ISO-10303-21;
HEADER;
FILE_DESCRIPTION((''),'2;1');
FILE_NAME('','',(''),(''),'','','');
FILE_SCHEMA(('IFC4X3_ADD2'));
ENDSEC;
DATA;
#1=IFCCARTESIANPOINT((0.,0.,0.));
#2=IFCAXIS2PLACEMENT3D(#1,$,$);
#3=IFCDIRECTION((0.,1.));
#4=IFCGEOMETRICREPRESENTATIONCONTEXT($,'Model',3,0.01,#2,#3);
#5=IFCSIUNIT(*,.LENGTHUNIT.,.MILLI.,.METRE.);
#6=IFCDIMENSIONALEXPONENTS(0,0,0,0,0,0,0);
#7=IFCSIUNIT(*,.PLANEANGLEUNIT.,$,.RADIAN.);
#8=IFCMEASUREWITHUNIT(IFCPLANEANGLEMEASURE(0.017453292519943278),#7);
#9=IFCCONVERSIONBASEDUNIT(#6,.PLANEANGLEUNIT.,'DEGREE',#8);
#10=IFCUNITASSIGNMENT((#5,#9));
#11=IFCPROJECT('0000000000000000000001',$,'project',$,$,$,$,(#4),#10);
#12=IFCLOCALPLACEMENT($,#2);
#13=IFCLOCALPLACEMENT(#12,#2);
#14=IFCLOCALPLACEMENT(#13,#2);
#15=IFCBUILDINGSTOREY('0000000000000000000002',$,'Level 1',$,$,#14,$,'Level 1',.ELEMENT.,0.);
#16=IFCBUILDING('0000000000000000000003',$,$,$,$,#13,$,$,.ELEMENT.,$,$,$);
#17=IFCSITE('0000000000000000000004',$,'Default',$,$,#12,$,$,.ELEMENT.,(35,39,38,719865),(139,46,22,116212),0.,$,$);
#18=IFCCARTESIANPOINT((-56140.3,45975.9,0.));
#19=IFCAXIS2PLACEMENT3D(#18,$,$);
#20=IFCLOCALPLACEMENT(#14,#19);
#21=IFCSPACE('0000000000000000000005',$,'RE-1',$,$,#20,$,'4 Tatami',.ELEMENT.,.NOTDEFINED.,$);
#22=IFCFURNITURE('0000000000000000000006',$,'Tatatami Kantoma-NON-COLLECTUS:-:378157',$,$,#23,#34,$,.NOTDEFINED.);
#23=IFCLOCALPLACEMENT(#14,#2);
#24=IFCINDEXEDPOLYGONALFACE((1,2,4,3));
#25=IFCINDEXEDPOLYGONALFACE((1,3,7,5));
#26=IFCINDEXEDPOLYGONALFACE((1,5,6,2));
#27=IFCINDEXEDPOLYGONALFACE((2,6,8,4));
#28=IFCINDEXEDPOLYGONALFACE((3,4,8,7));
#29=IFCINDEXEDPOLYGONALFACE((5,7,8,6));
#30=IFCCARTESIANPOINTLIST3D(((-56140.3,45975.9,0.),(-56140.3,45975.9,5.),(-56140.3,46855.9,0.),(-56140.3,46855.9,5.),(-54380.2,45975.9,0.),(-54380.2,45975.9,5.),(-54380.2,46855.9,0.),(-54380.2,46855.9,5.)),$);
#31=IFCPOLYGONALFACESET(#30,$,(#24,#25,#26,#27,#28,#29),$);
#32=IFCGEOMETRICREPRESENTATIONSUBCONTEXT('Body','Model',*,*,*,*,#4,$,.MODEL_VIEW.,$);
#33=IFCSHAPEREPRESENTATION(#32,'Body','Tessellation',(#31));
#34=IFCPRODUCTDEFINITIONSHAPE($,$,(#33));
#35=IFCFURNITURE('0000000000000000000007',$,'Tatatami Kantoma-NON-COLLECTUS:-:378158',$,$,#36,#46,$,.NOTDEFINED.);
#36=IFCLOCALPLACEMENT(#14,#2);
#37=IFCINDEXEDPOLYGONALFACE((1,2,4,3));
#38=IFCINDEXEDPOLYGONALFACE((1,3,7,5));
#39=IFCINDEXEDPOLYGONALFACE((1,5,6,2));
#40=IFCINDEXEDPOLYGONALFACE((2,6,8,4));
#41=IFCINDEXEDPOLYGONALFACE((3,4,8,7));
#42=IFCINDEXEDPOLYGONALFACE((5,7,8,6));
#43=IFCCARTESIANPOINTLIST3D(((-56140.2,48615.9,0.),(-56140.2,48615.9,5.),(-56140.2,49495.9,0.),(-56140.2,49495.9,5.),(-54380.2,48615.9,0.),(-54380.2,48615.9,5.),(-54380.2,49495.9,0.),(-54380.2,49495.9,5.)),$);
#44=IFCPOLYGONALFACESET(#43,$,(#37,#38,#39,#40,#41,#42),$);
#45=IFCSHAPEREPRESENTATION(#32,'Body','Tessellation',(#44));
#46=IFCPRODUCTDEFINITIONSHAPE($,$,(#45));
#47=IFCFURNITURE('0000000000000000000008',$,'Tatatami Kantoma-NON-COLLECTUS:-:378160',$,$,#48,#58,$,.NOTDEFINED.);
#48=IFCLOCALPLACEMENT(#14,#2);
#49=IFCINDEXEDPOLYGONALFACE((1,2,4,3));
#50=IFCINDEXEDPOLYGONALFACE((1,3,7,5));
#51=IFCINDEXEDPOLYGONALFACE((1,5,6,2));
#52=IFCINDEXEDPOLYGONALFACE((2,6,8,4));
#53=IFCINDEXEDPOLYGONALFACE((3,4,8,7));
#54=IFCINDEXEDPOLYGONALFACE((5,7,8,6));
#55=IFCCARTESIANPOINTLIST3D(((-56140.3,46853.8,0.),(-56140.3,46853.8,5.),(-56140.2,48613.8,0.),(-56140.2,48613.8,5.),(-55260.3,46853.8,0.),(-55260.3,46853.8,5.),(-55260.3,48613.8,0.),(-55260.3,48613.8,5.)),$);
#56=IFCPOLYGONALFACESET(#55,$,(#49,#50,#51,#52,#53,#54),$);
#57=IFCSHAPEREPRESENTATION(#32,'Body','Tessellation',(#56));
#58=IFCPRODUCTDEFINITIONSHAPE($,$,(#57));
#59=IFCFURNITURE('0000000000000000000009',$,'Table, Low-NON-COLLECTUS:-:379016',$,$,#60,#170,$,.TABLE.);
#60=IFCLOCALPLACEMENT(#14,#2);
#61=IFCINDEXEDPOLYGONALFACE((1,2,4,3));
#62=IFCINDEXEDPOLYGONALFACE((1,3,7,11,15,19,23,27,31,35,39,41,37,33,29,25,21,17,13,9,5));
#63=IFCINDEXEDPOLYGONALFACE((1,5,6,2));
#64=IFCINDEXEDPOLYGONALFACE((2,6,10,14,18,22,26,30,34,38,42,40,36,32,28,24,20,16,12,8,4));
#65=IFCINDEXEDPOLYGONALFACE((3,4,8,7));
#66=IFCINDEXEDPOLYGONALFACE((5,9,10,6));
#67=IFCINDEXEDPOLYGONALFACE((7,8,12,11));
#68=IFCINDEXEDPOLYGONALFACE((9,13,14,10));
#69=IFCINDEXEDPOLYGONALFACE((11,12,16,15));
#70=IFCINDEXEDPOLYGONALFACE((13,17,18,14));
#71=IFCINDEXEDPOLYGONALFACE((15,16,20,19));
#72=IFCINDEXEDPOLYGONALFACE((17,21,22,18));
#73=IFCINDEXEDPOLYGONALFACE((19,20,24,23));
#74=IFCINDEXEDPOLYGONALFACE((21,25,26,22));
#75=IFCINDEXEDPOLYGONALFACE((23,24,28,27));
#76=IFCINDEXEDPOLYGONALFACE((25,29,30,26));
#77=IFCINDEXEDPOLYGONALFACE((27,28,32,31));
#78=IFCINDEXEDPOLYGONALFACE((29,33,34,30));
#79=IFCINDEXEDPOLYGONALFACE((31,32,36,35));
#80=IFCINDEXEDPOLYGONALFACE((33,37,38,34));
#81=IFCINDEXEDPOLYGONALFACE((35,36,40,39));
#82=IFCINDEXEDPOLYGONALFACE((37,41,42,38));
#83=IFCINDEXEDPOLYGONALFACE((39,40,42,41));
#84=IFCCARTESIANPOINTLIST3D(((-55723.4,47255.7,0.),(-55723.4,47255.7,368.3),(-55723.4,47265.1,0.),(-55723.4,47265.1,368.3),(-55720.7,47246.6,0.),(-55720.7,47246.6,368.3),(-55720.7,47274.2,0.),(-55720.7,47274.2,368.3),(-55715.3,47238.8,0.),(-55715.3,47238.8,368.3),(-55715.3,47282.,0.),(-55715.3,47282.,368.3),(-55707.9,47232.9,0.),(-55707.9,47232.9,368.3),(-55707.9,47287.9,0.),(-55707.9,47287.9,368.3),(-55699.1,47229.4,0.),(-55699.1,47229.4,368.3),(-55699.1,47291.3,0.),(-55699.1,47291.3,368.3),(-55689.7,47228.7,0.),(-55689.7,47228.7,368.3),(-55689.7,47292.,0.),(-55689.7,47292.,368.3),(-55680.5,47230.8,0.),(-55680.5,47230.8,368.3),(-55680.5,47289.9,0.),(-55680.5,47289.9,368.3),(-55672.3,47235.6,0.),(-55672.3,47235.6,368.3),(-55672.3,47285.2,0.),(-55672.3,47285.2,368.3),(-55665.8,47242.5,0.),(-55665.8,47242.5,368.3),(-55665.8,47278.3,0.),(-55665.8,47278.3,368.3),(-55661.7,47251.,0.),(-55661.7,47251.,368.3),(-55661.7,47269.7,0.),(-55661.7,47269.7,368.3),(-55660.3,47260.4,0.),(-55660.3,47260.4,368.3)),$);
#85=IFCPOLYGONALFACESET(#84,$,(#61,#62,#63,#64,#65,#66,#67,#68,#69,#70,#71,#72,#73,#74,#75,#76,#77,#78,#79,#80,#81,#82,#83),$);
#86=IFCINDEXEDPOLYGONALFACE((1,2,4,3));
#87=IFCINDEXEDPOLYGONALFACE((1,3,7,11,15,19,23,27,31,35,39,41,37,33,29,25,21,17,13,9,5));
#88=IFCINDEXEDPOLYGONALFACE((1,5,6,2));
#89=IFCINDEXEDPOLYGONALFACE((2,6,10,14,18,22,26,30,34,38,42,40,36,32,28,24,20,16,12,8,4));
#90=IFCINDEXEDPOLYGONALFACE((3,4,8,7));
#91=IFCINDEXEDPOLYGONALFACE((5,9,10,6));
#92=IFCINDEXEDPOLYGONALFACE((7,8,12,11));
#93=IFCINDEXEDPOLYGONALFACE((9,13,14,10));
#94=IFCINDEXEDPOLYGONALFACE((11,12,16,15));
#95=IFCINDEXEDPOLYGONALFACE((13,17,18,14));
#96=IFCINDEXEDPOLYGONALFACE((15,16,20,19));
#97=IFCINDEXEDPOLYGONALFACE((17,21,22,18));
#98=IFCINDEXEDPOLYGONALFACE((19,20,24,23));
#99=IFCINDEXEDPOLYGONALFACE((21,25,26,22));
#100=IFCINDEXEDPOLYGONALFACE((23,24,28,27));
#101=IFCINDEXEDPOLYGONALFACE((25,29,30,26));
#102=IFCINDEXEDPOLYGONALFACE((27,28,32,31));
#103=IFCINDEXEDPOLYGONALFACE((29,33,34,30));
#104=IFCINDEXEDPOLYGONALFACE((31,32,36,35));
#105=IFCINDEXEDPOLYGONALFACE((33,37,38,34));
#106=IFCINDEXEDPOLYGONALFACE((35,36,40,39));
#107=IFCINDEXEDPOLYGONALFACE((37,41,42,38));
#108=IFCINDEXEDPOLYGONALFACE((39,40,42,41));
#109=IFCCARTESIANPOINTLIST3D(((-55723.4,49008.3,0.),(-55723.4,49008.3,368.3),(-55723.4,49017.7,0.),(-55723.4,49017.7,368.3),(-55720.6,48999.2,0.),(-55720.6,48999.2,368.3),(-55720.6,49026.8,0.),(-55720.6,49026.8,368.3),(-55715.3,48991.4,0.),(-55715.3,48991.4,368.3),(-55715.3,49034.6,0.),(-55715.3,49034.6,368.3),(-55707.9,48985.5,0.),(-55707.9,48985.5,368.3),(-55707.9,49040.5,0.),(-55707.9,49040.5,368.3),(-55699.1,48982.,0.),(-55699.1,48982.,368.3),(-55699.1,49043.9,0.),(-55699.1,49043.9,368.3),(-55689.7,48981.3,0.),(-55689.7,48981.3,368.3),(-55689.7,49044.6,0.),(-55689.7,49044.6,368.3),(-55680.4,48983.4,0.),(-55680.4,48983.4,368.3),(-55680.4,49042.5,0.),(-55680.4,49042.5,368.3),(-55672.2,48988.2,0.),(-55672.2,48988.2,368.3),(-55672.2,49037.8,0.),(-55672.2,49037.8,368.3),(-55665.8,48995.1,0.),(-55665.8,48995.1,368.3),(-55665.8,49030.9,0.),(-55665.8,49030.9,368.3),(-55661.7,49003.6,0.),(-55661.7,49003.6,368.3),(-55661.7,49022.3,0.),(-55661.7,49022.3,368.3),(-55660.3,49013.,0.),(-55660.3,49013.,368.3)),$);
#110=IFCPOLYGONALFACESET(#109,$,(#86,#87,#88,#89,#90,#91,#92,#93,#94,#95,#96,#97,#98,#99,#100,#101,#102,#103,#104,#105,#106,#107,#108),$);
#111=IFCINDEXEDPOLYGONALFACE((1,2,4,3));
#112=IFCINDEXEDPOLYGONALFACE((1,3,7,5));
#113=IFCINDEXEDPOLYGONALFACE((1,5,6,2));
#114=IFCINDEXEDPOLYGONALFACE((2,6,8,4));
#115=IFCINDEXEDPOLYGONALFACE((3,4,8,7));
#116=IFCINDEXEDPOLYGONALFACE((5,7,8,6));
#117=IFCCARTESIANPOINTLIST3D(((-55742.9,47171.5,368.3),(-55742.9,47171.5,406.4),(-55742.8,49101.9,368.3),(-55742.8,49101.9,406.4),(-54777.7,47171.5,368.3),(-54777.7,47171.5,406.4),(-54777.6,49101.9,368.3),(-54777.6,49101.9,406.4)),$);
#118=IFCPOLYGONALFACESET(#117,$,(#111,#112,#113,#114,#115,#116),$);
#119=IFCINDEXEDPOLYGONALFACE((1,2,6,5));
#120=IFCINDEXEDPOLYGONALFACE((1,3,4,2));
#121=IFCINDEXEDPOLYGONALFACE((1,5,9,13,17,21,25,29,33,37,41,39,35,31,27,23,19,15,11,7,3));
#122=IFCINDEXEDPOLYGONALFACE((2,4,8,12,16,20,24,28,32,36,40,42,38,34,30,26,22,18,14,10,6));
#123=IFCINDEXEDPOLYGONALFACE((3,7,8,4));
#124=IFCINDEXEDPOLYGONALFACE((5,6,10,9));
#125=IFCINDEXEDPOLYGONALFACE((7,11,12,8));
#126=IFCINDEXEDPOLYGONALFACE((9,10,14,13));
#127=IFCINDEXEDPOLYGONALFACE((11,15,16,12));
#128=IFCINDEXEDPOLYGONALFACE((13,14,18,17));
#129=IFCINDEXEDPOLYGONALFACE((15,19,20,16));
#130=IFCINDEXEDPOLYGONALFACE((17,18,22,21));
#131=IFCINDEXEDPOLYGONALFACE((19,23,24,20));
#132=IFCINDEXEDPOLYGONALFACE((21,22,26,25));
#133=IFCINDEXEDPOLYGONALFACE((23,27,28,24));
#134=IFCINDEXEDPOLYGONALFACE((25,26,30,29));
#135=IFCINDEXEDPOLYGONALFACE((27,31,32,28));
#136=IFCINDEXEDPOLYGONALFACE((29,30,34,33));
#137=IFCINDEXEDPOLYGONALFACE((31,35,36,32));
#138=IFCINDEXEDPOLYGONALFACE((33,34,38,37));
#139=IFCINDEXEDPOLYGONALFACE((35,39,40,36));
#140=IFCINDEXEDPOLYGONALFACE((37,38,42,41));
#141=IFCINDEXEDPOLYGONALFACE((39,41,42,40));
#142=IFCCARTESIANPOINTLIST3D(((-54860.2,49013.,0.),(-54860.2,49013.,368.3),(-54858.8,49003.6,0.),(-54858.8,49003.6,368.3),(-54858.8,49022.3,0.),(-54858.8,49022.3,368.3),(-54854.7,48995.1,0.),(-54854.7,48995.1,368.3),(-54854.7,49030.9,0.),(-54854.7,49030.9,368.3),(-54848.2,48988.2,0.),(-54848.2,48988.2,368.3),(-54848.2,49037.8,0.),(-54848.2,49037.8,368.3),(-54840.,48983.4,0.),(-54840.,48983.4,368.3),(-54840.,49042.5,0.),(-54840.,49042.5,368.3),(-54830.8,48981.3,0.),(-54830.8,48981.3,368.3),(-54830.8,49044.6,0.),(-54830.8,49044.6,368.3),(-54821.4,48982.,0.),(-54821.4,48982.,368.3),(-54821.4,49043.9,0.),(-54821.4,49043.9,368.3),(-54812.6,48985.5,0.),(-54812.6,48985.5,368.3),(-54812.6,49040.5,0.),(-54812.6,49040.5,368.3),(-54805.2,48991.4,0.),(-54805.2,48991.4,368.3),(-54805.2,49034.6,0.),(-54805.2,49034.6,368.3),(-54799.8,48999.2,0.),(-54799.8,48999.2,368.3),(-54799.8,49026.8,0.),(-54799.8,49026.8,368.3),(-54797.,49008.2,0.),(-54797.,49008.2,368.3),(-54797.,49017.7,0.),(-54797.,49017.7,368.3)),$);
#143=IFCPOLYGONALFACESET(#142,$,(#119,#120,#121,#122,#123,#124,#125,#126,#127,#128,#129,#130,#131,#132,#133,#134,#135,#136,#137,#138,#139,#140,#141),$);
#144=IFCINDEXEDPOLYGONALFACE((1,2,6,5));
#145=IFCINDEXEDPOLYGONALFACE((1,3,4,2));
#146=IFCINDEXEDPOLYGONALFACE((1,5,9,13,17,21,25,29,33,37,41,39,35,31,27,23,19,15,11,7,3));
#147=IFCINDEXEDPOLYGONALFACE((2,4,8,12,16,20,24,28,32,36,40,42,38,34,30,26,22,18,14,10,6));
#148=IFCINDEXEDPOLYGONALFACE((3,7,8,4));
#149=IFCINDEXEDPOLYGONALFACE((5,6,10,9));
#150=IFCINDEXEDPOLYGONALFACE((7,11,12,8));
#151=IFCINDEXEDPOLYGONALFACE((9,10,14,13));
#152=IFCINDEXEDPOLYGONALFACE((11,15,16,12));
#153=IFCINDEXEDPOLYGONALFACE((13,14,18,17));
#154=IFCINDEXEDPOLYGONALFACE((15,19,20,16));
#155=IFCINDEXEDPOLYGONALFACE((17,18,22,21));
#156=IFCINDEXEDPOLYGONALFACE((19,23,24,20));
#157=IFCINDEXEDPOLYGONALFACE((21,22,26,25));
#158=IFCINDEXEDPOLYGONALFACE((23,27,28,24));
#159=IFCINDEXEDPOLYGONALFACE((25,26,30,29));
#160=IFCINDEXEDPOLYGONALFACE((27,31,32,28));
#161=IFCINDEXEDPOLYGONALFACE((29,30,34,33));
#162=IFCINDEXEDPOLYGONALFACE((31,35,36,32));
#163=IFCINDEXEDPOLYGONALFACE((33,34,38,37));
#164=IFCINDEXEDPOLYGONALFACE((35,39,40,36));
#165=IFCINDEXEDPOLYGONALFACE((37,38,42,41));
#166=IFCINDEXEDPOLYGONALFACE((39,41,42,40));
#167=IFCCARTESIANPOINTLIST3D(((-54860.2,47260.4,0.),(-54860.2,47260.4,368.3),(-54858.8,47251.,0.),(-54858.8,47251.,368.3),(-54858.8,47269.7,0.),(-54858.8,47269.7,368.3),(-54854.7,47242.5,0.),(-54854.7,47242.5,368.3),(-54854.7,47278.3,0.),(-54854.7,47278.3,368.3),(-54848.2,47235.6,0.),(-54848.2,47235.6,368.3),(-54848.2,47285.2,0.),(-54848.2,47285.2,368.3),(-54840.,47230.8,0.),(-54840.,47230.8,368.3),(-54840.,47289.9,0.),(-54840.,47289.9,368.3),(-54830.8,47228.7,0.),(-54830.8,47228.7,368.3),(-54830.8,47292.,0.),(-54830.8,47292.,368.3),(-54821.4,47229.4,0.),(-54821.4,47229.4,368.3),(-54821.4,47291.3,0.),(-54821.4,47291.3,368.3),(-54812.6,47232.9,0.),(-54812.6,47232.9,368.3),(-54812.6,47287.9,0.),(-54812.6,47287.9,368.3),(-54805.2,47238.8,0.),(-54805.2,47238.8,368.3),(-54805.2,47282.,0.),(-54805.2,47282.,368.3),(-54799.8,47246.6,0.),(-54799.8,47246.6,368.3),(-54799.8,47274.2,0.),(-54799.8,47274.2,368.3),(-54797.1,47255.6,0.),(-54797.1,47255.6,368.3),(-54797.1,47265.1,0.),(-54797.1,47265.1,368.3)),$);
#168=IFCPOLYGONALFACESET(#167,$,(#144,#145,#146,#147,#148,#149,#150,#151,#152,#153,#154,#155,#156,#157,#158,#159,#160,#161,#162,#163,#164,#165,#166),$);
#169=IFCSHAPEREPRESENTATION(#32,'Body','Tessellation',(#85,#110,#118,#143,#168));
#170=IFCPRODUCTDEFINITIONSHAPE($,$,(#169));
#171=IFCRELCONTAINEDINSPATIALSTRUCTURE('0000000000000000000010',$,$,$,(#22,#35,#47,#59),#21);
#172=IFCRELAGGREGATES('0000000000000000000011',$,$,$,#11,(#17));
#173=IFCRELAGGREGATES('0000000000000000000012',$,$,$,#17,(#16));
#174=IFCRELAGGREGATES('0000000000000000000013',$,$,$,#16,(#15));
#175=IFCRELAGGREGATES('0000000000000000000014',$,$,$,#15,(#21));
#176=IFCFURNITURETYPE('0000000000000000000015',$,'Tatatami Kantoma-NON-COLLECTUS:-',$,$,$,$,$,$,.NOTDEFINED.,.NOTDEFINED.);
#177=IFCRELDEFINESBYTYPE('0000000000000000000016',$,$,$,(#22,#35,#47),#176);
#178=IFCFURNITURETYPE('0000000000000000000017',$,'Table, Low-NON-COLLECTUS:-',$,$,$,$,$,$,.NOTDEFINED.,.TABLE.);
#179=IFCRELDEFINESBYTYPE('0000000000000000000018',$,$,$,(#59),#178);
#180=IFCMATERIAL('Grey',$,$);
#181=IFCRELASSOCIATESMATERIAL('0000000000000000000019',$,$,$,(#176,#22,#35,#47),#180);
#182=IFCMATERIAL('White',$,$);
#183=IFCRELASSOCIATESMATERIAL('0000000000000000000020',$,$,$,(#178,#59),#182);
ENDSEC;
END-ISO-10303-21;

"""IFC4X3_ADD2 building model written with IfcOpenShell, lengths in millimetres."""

from ifc_helpers import new_model, entity, si_unit, converted_unit, direction, frame, frame_2d, origin, origin_2d_with_axis, place, context, subcontext, project, spatial, rectangle, circle, extrude, source, transform, mapped, material, type_object, type_shapes, element, save


model = new_model("IFC4X3_ADD2")

# Units and contexts
model_context = context("Model", 3, precision=0.01, world=origin(), true_north=direction((0.0, 1.0)))
body_context = subcontext(model_context, "Body", "Model", "MODEL_VIEW")
ifc_project = project(units=[si_unit("LENGTHUNIT", "METRE", prefix="MILLI"), converted_unit("PLANEANGLEUNIT", "DEGREE", entity("IfcPlaneAngleMeasure", 0.017453292519943278), si_unit("PLANEANGLEUNIT", "RADIAN"), dimensions=[0, 0, 0, 0, 0, 0, 0])], contexts=[model_context])

# Site, building, storey
site_placement = place(None, origin())
site = spatial("IfcSite", under=ifc_project, at=site_placement, Name="Default", CompositionType="ELEMENT", RefLatitude=(35, 39, 38, 719865), RefLongitude=(139, 46, 22, 116212), RefElevation=0.0)
building_placement = place(site_placement, origin())
building = spatial("IfcBuilding", under=site, at=building_placement, CompositionType="ELEMENT")
storey_placement = place(building_placement, origin())
storey = spatial("IfcBuildingStorey", under=building, at=storey_placement, Name="Level 1", LongName="Level 1", CompositionType="ELEMENT", Elevation=0.0)

# Shared definitions
ifc_material_1 = material(Name="White")

# Shared definitions
space_1_placement = place(storey_placement, frame((-56140.3, 45975.9, 0.0)))
space_1 = spatial("IfcSpace", under=storey, at=space_1_placement, Name="RE-1", LongName="4 Tatami", CompositionType="ELEMENT", PredefinedType="NOTDEFINED")

# Furniture
ifc_material_2 = material(Name="Grey")
furniture_type_1 = type_object("IfcFurnitureType", Name="Tatatami Kantoma-NON-COLLECTUS:-", AssemblyPlace="NOTDEFINED", PredefinedType="NOTDEFINED", material=ifc_material_2)
shared_shape_1 = source(origin(), body_context, "Body", "SweptSolid", [
    extrude(rectangle(XDim=1760.0, YDim=880.0, at=origin_2d_with_axis()), frame((880.0, 440.0, 0.0), z_axis=(0.0, 0.0, 1.0), x_axis=(-1.0, 0.0, 0.0)), (0.0, 0.0, 1.0), 5.0),
])
type_shapes(furniture_type_1, [shared_shape_1])
for number, where, name in (
    (1, (0.0, 0.0, 0.0), "Tatatami Kantoma-NON-COLLECTUS:-:378157"),
    (2, (0.0, 2640.0, 0.0), "Tatatami Kantoma-NON-COLLECTUS:-:378158"),
):
    element("IfcFurniture", number, at=place(space_1_placement, frame(where)), inside=space_1, type_object=furniture_type_1, material=ifc_material_2, Name=name, PredefinedType="NOTDEFINED", context=body_context, shape_type="MappedRepresentation", body=[
        mapped(shared_shape_1, transform((0.0, 0.0, 0.0), scale=1.0)),
    ])
for number, where, z_axis, x_axis, name in (
    (3, (0.0, 2637.9, 0.0), (0.0, 0.0, 1.0), (-0.000004, -1.0, 0.0), "Tatatami Kantoma-NON-COLLECTUS:-:378160"),
):
    element("IfcFurniture", number, at=place(space_1_placement, frame(where, z_axis=z_axis, x_axis=x_axis)), inside=space_1, type_object=furniture_type_1, material=ifc_material_2, Name=name, PredefinedType="NOTDEFINED", context=body_context, shape_type="MappedRepresentation", body=[
        mapped(shared_shape_1, transform((0.0, 0.0, 0.0), scale=1.0)),
    ])
furniture_type_2 = type_object("IfcFurnitureType", Name="Table, Low-NON-COLLECTUS:-", AssemblyPlace="NOTDEFINED", PredefinedType="TABLE", material=ifc_material_1)
shared_shape_2 = source(origin(), body_context, "Body", "SweptSolid", [
    extrude(circle(Radius=31.8, at=frame_2d((0.0, 0.0), x_axis=(1.0, 0.0))), frame((876.3, -431.8, 0.0), z_axis=(0.0, 0.0, 1.0), x_axis=(0.0, 1.0, 0.0)), (0.0, 0.0, 1.0), 368.3),
    extrude(circle(Radius=31.8, at=origin_2d_with_axis()), frame((-876.3, -431.8, 0.0), z_axis=(0.0, 0.0, 1.0), x_axis=(0.0, 1.0, 0.0)), (0.0, 0.0, 1.0), 368.3),
    extrude(rectangle(XDim=1930.4, YDim=965.2, at=origin_2d_with_axis()), frame((0.0, 0.0, 368.3), z_axis=(0.0, 0.0, 1.0), x_axis=(-1.0, 0.0, 0.0)), (0.0, 0.0, 1.0), 38.1),
    extrude(circle(Radius=31.8, at=origin_2d_with_axis()), frame((-876.3, 431.8, 0.0), z_axis=(0.0, 0.0, 1.0), x_axis=(0.0, -1.0, 0.0)), (0.0, 0.0, 1.0), 368.3),
    extrude(circle(Radius=31.8, at=frame_2d((0.0, 0.0), x_axis=(1.0, 0.0))), frame((876.3, 431.8, 0.0), z_axis=(0.0, 0.0, 1.0), x_axis=(0.0, -1.0, 0.0)), (0.0, 0.0, 1.0), 368.3),
])
type_shapes(furniture_type_2, [shared_shape_2])
furniture_1_placement = place(space_1_placement, frame((880.0, 2160.8, 0.0), z_axis=(0.0, 0.0, 1.0), x_axis=(-0.000004, -1.0, 0.0)))
element("IfcFurniture", 4, at=furniture_1_placement, inside=space_1, type_object=furniture_type_2, material=ifc_material_1, Name="Table, Low-NON-COLLECTUS:-:379016", PredefinedType="TABLE", context=body_context, shape_type="MappedRepresentation", body=[
    mapped(shared_shape_2, transform((0.0, 0.0, 0.0), scale=1.0)),
])

save(model, "model.ifc")
